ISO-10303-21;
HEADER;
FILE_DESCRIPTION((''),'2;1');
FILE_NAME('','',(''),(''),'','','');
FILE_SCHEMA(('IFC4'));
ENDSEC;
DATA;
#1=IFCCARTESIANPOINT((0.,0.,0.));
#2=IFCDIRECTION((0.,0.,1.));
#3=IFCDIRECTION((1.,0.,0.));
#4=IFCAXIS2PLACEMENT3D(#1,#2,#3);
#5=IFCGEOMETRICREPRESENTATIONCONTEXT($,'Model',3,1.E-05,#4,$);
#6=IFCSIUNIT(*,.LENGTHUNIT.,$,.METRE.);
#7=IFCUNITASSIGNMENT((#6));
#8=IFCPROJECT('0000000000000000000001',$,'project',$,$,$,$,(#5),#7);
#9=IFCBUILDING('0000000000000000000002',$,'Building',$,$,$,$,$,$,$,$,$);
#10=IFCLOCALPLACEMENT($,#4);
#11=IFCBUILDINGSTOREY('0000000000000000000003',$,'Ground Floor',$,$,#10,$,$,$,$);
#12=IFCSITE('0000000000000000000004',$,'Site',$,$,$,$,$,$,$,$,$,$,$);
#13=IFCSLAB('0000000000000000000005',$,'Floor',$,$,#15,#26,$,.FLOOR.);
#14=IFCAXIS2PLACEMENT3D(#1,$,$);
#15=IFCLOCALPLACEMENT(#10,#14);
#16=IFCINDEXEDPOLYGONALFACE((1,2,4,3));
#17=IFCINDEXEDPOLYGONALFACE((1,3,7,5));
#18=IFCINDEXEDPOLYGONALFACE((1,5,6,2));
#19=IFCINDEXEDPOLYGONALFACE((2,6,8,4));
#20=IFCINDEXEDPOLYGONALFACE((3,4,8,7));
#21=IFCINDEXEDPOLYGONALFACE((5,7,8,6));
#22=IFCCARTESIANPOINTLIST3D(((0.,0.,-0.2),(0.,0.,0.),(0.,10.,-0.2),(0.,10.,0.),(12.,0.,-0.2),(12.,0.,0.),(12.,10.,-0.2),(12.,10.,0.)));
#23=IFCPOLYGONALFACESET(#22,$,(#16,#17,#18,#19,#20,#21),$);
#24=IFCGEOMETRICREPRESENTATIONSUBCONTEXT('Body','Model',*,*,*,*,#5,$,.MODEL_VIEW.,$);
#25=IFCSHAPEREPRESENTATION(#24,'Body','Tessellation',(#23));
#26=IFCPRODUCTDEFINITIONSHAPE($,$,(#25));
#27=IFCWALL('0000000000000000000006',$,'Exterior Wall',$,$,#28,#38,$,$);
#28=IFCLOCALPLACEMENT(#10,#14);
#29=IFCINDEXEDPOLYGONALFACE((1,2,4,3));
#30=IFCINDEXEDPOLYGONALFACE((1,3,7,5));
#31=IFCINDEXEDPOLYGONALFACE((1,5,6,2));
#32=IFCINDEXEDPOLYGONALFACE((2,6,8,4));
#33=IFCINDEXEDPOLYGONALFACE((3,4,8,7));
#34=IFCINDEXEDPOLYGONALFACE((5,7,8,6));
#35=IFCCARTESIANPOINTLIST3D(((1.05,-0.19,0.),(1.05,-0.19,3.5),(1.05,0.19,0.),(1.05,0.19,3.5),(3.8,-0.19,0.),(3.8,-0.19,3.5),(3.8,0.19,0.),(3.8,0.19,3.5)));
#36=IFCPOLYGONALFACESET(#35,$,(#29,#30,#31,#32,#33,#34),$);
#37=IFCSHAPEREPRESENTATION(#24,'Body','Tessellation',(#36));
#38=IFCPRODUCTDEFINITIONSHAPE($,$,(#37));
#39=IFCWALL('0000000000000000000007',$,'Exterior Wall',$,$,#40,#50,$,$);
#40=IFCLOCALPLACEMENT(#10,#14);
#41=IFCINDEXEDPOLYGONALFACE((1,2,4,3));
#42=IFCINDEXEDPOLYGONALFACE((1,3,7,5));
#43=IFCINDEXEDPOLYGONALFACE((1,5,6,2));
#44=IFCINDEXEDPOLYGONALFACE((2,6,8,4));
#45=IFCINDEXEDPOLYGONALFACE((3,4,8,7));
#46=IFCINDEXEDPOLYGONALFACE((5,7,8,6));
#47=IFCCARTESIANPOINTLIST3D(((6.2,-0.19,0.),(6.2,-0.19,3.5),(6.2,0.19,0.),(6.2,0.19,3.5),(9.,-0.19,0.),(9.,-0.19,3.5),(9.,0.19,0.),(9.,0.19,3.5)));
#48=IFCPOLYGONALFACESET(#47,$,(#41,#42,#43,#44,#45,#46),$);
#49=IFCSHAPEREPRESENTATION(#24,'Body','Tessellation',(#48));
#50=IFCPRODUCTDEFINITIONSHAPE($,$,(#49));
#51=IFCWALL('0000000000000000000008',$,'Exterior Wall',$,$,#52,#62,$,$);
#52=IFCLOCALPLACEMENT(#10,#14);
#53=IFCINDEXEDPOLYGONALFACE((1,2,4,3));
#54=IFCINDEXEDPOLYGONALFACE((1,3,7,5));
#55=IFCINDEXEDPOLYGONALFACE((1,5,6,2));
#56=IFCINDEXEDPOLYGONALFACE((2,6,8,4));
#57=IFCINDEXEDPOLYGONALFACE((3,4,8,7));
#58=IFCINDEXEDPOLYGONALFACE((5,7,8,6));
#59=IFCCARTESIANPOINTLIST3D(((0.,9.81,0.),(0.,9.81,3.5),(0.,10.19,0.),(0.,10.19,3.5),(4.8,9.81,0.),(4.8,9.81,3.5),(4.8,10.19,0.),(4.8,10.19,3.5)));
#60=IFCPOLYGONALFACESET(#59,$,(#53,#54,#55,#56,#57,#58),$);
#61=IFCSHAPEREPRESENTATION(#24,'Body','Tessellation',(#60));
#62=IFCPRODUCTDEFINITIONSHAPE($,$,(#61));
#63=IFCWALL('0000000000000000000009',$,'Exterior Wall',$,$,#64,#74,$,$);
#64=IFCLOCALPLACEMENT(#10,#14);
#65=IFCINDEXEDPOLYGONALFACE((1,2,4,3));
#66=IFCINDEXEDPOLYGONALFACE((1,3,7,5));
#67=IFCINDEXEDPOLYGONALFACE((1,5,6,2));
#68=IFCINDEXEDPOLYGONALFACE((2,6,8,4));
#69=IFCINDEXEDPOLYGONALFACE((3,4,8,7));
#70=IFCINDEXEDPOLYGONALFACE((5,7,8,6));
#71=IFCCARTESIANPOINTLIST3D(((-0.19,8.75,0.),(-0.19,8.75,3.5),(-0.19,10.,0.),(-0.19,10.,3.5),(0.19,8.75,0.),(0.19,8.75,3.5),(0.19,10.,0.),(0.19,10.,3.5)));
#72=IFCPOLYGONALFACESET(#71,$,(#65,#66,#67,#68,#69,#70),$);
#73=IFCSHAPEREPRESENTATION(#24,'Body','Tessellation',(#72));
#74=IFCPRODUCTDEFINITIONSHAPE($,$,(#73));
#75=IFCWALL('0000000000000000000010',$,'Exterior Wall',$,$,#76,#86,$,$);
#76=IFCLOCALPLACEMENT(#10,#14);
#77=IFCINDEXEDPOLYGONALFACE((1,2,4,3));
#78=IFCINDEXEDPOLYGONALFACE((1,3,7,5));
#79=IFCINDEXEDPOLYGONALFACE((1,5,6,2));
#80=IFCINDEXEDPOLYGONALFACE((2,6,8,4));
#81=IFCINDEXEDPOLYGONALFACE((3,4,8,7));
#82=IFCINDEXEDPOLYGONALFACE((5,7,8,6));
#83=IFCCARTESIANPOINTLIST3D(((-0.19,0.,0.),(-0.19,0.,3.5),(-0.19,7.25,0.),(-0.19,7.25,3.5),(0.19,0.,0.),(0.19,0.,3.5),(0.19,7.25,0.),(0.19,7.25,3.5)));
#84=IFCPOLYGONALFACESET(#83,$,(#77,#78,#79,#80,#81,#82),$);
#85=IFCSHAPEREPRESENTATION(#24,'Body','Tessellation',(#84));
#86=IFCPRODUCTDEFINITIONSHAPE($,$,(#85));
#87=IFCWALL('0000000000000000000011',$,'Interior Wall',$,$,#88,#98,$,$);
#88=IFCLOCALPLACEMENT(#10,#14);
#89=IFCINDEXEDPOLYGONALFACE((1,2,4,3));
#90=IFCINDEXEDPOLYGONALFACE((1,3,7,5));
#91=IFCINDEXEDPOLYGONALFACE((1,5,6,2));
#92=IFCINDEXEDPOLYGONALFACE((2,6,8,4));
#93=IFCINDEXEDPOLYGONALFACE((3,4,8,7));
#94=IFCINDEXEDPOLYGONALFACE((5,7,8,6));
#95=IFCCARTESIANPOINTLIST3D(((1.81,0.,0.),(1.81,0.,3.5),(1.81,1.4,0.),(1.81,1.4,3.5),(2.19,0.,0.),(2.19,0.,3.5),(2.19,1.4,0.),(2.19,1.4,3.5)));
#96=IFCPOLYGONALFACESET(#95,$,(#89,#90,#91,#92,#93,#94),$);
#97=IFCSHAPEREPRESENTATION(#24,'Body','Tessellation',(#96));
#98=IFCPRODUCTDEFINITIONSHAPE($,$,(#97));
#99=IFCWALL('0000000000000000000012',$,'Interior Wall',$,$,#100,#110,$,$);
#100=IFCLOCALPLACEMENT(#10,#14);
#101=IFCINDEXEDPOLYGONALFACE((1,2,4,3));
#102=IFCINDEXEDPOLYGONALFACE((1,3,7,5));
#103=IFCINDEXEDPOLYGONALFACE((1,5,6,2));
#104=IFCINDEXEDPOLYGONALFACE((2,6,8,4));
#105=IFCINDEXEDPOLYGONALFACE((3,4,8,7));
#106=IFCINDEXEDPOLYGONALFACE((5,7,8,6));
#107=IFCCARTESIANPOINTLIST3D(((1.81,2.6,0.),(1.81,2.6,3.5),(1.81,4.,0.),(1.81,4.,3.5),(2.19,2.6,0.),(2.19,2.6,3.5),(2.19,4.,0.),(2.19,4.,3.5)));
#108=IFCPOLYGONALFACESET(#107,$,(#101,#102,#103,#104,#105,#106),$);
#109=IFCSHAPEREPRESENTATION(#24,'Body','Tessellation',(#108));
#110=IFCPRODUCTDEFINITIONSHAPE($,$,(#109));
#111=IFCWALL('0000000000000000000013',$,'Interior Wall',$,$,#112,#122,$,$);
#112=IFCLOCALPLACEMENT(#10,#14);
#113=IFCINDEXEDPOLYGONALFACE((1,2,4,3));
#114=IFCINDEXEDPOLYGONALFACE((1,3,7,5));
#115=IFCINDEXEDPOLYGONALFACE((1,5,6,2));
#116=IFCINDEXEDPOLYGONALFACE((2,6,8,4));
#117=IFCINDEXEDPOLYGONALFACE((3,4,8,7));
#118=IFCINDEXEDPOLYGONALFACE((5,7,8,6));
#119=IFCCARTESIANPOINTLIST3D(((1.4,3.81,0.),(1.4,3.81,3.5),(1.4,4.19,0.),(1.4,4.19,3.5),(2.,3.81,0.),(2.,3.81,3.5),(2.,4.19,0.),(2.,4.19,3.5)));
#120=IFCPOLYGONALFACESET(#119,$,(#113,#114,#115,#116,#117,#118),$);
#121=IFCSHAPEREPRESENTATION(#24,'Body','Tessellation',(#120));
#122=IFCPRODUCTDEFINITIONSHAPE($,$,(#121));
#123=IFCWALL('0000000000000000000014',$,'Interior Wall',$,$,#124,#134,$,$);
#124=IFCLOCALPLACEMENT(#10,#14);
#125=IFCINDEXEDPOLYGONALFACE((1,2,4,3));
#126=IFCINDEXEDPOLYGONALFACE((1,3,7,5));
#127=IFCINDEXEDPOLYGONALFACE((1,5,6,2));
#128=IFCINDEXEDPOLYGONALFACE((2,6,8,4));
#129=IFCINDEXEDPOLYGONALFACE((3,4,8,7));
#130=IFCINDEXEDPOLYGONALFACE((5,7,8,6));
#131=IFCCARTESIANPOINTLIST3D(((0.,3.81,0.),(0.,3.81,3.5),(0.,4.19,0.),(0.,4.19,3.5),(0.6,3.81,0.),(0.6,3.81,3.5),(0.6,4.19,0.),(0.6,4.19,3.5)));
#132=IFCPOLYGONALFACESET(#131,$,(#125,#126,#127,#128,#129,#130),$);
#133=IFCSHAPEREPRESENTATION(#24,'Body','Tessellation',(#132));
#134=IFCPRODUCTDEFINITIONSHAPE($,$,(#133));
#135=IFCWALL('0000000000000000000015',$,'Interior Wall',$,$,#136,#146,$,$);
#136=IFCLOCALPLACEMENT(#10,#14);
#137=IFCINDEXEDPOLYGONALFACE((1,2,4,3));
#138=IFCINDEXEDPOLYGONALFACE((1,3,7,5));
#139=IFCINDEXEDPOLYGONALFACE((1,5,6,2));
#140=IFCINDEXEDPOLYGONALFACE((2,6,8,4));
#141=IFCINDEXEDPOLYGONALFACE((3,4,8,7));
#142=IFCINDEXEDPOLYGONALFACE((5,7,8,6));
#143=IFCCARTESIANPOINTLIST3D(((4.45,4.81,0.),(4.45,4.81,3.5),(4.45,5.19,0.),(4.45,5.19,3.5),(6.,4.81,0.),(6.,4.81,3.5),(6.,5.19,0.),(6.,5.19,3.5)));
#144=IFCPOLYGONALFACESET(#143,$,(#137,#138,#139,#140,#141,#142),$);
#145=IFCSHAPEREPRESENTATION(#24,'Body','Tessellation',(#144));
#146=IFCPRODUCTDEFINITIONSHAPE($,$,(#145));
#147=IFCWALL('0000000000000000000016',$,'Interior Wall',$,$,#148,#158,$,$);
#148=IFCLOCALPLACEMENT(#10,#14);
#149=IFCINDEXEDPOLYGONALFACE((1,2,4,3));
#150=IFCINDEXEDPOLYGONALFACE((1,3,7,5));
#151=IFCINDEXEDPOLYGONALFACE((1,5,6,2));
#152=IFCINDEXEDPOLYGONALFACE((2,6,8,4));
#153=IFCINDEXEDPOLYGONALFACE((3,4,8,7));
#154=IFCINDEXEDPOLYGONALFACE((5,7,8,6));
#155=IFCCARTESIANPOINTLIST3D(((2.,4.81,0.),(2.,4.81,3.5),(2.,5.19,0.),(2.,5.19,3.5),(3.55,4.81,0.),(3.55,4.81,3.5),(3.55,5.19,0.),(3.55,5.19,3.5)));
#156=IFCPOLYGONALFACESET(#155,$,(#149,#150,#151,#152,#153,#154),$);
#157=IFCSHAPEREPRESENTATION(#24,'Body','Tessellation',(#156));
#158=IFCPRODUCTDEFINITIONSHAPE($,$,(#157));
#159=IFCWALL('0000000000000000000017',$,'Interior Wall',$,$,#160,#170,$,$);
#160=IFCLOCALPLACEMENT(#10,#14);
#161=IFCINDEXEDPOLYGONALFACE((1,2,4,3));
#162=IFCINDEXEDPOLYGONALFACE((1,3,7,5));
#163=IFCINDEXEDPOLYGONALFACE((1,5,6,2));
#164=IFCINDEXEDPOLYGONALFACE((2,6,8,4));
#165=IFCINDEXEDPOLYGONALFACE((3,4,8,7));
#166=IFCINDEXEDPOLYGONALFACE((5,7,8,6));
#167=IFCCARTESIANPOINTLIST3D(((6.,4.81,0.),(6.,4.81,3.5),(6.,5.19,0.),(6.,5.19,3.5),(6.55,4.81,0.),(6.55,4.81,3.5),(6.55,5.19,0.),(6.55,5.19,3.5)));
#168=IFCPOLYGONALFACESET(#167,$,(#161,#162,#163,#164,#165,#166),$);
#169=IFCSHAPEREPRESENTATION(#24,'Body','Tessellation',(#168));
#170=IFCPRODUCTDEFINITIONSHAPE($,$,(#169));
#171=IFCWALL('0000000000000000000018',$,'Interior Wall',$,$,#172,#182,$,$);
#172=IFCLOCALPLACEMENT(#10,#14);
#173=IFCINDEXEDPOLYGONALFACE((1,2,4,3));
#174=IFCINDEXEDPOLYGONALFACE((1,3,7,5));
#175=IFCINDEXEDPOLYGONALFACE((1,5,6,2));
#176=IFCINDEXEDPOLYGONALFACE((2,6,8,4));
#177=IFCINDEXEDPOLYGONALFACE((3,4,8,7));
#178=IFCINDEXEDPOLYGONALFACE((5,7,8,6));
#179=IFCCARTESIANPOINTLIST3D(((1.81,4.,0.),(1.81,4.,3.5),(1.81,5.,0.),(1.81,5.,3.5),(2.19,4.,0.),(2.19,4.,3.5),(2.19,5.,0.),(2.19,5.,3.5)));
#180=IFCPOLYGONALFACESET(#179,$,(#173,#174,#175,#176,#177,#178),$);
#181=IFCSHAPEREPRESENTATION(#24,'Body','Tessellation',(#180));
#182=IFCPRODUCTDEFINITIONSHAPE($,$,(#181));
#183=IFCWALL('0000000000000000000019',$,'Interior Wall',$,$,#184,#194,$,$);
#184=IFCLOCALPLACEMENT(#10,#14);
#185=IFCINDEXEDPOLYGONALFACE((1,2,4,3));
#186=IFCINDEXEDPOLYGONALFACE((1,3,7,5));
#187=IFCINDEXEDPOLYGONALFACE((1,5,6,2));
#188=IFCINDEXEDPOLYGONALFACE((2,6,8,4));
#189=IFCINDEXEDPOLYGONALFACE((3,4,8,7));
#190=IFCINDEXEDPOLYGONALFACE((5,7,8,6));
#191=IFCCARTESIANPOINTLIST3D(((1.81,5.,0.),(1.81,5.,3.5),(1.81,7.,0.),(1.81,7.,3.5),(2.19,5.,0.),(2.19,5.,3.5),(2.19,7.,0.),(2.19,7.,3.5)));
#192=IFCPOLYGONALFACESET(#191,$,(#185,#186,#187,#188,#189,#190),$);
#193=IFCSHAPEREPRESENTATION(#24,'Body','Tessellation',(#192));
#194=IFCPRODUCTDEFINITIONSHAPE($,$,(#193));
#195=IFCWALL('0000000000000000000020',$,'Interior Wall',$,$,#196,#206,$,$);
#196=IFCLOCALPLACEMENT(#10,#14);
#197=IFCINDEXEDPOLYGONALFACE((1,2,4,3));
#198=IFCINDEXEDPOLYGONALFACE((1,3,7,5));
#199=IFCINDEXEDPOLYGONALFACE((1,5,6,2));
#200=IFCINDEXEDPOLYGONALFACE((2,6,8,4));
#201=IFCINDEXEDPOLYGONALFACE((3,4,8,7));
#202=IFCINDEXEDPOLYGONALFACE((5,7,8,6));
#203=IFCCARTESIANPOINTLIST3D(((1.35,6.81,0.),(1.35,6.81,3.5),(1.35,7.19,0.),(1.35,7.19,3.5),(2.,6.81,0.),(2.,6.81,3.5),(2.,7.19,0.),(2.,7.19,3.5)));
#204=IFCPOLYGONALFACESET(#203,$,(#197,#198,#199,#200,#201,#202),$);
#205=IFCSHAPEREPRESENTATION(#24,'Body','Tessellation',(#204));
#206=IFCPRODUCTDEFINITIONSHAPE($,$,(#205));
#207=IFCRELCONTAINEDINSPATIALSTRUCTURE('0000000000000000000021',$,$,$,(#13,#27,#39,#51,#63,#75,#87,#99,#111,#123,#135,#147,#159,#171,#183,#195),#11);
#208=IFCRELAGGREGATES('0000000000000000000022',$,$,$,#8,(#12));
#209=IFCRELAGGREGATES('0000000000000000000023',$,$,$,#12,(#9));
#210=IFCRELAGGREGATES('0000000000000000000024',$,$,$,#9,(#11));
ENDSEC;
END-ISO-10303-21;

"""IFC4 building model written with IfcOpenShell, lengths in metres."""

from ifc_helpers import new_model, si_unit, frame, origin_with_axes, place, context, subcontext, project, spatial, indexed_curve, outline, extrude, element, save


model = new_model("IFC4")

# Units and contexts
model_context = context("Model", 3, precision=1e-05, world=origin_with_axes())
body_context = subcontext(model_context, "Body", "Model", "MODEL_VIEW")
ifc_project = project(units=[si_unit("LENGTHUNIT", "METRE")], contexts=[model_context])

# Site, building, storey
site = spatial("IfcSite", under=ifc_project, Name="Site")
building = spatial("IfcBuilding", under=site, Name="Building")
storey_placement = place(None, origin_with_axes())
storey = spatial("IfcBuildingStorey", under=building, at=storey_placement, Name="Ground Floor")

# Slab
slab_placement = place(storey_placement, frame((0.0, 0.0, -0.2), z_axis=(0.0, 0.0, 1.0), x_axis=(1.0, 0.0, 0.0)))
element("IfcSlab", 1, at=slab_placement, inside=storey, Name="Floor", PredefinedType="FLOOR", context=body_context, shape_type="SweptSolid", body=[
    extrude(outline(indexed_curve([(0.0, 0.0), (12.0, 0.0), (12.0, 10.0), (0.0, 10.0)])), None, (0.0, 0.0, 1.0), 0.2),
])

# Walls
wall_1_placement = place(storey_placement, frame((1.05, 0.0, 0.0), z_axis=(0.0, 0.0, 1.0), x_axis=(1.0, 0.0, 0.0)))
element("IfcWall", 2, at=wall_1_placement, inside=storey, Name="Exterior Wall", context=body_context, shape_type="SweptSolid", body=[
    extrude(outline(indexed_curve([(0.0, 0.0), (0.0, 0.38), (2.75, 0.38), (2.75, 0.0), (0.0, 0.0)], self_intersect=False)), frame((0.0, -0.19, 0.0), z_axis=(0.0, 0.0, 1.0), x_axis=(1.0, 0.0, 0.0)), (0.0, 0.0, 1.0), 3.5),
])
wall_2_placement = place(storey_placement, frame((6.2, 0.0, 0.0), z_axis=(0.0, 0.0, 1.0), x_axis=(1.0, 0.0, 0.0)))
element("IfcWall", 3, at=wall_2_placement, inside=storey, Name="Exterior Wall", context=body_context, shape_type="SweptSolid", body=[
    extrude(outline(indexed_curve([(0.0, 0.0), (0.0, 0.38), (2.8, 0.38), (2.8, 0.0), (0.0, 0.0)], self_intersect=False)), frame((0.0, -0.19, 0.0), z_axis=(0.0, 0.0, 1.0), x_axis=(1.0, 0.0, 0.0)), (0.0, 0.0, 1.0), 3.5),
])
wall_3_placement = place(storey_placement, frame((4.8, 10.0, 0.0), z_axis=(0.0, 0.0, 1.0), x_axis=(-1.0, 0.0, 0.0)))
element("IfcWall", 4, at=wall_3_placement, inside=storey, Name="Exterior Wall", context=body_context, shape_type="SweptSolid", body=[
    extrude(outline(indexed_curve([(0.0, 0.0), (0.0, 0.38), (4.8, 0.38), (4.8, 0.0), (0.0, 0.0)], self_intersect=False)), frame((0.0, -0.19, 0.0), z_axis=(0.0, 0.0, 1.0), x_axis=(1.0, 0.0, 0.0)), (0.0, 0.0, 1.0), 3.5),
])
wall_4_placement = place(storey_placement, frame((0.0, 10.0, 0.0), z_axis=(0.0, 0.0, 1.0), x_axis=(0.0, -1.0, 0.0)))
element("IfcWall", 5, at=wall_4_placement, inside=storey, Name="Exterior Wall", context=body_context, shape_type="SweptSolid", body=[
    extrude(outline(indexed_curve([(0.0, 0.0), (0.0, 0.38), (1.25, 0.38), (1.25, 0.0), (0.0, 0.0)], self_intersect=False)), frame((0.0, -0.19, 0.0), z_axis=(0.0, 0.0, 1.0), x_axis=(1.0, 0.0, 0.0)), (0.0, 0.0, 1.0), 3.5),
])
wall_5_placement = place(storey_placement, frame((0.0, 7.25, 0.0), z_axis=(0.0, 0.0, 1.0), x_axis=(0.0, -1.0, 0.0)))
element("IfcWall", 6, at=wall_5_placement, inside=storey, Name="Exterior Wall", context=body_context, shape_type="SweptSolid", body=[
    extrude(outline(indexed_curve([(0.0, 0.0), (0.0, 0.38), (7.25, 0.38), (7.25, 0.0), (0.0, 0.0)], self_intersect=False)), frame((0.0, -0.19, 0.0), z_axis=(0.0, 0.0, 1.0), x_axis=(1.0, 0.0, 0.0)), (0.0, 0.0, 1.0), 3.5),
])
for number, where, z_axis, x_axis, name in (
    (7, (2.0, 0.0, 0.0), (0.0, 0.0, 1.0), (0.0, 1.0, 0.0), "Interior Wall"),
    (8, (2.0, 2.6, 0.0), (0.0, 0.0, 1.0), (0.0, 1.0, 0.0), "Interior Wall"),
):
    element("IfcWall", number, at=place(storey_placement, frame(where, z_axis=z_axis, x_axis=x_axis)), inside=storey, Name=name, context=body_context, shape_type="SweptSolid", body=[
        extrude(outline(indexed_curve([(0.0, 0.0), (0.0, 0.38), (1.4, 0.38), (1.4, 0.0), (0.0, 0.0)], self_intersect=False)), frame((0.0, -0.19, 0.0), z_axis=(0.0, 0.0, 1.0), x_axis=(1.0, 0.0, 0.0)), (0.0, 0.0, 1.0), 3.5),
    ])
for number, where, z_axis, x_axis, name in (
    (9, (2.0, 4.0, 0.0), (0.0, 0.0, 1.0), (-1.0, 0.0, 0.0), "Interior Wall"),
    (10, (0.6, 4.0, 0.0), (0.0, 0.0, 1.0), (-1.0, 0.0, 0.0), "Interior Wall"),
):
    element("IfcWall", number, at=place(storey_placement, frame(where, z_axis=z_axis, x_axis=x_axis)), inside=storey, Name=name, context=body_context, shape_type="SweptSolid", body=[
        extrude(outline(indexed_curve([(0.0, 0.0), (0.0, 0.38), (0.6, 0.38), (0.6, 0.0), (0.0, 0.0)], self_intersect=False)), frame((0.0, -0.19, 0.0), z_axis=(0.0, 0.0, 1.0), x_axis=(1.0, 0.0, 0.0)), (0.0, 0.0, 1.0), 3.5),
    ])
for number, where, z_axis, x_axis, name in (
    (11, (6.0, 5.0, 0.0), (0.0, 0.0, 1.0), (-1.0, 0.0, 0.0), "Interior Wall"),
    (12, (3.55, 5.0, 0.0), (0.0, 0.0, 1.0), (-1.0, 0.0, 0.0), "Interior Wall"),
):
    element("IfcWall", number, at=place(storey_placement, frame(where, z_axis=z_axis, x_axis=x_axis)), inside=storey, Name=name, context=body_context, shape_type="SweptSolid", body=[
        extrude(outline(indexed_curve([(0.0, 0.0), (0.0, 0.38), (1.55, 0.38), (1.55, 0.0), (0.0, 0.0)], self_intersect=False)), frame((0.0, -0.19, 0.0), z_axis=(0.0, 0.0, 1.0), x_axis=(1.0, 0.0, 0.0)), (0.0, 0.0, 1.0), 3.5),
    ])
wall_6_placement = place(storey_placement, frame((6.55, 5.0, 0.0), z_axis=(0.0, 0.0, 1.0), x_axis=(-1.0, 0.0, 0.0)))
element("IfcWall", 13, at=wall_6_placement, inside=storey, Name="Interior Wall", context=body_context, shape_type="SweptSolid", body=[
    extrude(outline(indexed_curve([(0.0, 0.0), (0.0, 0.38), (0.55, 0.38), (0.55, 0.0), (0.0, 0.0)], self_intersect=False)), frame((0.0, -0.19, 0.0), z_axis=(0.0, 0.0, 1.0), x_axis=(1.0, 0.0, 0.0)), (0.0, 0.0, 1.0), 3.5),
])
wall_7_placement = place(storey_placement, frame((2.0, 5.0, 0.0), z_axis=(0.0, 0.0, 1.0), x_axis=(0.0, -1.0, 0.0)))
element("IfcWall", 14, at=wall_7_placement, inside=storey, Name="Interior Wall", context=body_context, shape_type="SweptSolid", body=[
    extrude(outline(indexed_curve([(0.0, 0.0), (0.0, 0.38), (1.0, 0.38), (1.0, 0.0), (0.0, 0.0)], self_intersect=False)), frame((0.0, -0.19, 0.0), z_axis=(0.0, 0.0, 1.0), x_axis=(1.0, 0.0, 0.0)), (0.0, 0.0, 1.0), 3.5),
])
wall_8_placement = place(storey_placement, frame((2.0, 5.0, 0.0), z_axis=(0.0, 0.0, 1.0), x_axis=(0.0, 1.0, 0.0)))
element("IfcWall", 15, at=wall_8_placement, inside=storey, Name="Interior Wall", context=body_context, shape_type="SweptSolid", body=[
    extrude(outline(indexed_curve([(0.0, 0.0), (0.0, 0.38), (2.0, 0.38), (2.0, 0.0), (0.0, 0.0)], self_intersect=False)), frame((0.0, -0.19, 0.0), z_axis=(0.0, 0.0, 1.0), x_axis=(1.0, 0.0, 0.0)), (0.0, 0.0, 1.0), 3.5),
])
for number, where, z_axis, x_axis, name in (
    (16, (2.0, 7.0, 0.0), (0.0, 0.0, 1.0), (-1.0, 0.0, 0.0), "Interior Wall"),
):
    element("IfcWall", number, at=place(storey_placement, frame(where, z_axis=z_axis, x_axis=x_axis)), inside=storey, Name=name, context=body_context, shape_type="SweptSolid", body=[
        extrude(outline(indexed_curve([(0.0, 0.0), (0.0, 0.38), (0.65, 0.38), (0.65, 0.0), (0.0, 0.0)], self_intersect=False)), frame((0.0, -0.19, 0.0), z_axis=(0.0, 0.0, 1.0), x_axis=(1.0, 0.0, 0.0)), (0.0, 0.0, 1.0), 3.5),
    ])

save(model, "model.ifc")
